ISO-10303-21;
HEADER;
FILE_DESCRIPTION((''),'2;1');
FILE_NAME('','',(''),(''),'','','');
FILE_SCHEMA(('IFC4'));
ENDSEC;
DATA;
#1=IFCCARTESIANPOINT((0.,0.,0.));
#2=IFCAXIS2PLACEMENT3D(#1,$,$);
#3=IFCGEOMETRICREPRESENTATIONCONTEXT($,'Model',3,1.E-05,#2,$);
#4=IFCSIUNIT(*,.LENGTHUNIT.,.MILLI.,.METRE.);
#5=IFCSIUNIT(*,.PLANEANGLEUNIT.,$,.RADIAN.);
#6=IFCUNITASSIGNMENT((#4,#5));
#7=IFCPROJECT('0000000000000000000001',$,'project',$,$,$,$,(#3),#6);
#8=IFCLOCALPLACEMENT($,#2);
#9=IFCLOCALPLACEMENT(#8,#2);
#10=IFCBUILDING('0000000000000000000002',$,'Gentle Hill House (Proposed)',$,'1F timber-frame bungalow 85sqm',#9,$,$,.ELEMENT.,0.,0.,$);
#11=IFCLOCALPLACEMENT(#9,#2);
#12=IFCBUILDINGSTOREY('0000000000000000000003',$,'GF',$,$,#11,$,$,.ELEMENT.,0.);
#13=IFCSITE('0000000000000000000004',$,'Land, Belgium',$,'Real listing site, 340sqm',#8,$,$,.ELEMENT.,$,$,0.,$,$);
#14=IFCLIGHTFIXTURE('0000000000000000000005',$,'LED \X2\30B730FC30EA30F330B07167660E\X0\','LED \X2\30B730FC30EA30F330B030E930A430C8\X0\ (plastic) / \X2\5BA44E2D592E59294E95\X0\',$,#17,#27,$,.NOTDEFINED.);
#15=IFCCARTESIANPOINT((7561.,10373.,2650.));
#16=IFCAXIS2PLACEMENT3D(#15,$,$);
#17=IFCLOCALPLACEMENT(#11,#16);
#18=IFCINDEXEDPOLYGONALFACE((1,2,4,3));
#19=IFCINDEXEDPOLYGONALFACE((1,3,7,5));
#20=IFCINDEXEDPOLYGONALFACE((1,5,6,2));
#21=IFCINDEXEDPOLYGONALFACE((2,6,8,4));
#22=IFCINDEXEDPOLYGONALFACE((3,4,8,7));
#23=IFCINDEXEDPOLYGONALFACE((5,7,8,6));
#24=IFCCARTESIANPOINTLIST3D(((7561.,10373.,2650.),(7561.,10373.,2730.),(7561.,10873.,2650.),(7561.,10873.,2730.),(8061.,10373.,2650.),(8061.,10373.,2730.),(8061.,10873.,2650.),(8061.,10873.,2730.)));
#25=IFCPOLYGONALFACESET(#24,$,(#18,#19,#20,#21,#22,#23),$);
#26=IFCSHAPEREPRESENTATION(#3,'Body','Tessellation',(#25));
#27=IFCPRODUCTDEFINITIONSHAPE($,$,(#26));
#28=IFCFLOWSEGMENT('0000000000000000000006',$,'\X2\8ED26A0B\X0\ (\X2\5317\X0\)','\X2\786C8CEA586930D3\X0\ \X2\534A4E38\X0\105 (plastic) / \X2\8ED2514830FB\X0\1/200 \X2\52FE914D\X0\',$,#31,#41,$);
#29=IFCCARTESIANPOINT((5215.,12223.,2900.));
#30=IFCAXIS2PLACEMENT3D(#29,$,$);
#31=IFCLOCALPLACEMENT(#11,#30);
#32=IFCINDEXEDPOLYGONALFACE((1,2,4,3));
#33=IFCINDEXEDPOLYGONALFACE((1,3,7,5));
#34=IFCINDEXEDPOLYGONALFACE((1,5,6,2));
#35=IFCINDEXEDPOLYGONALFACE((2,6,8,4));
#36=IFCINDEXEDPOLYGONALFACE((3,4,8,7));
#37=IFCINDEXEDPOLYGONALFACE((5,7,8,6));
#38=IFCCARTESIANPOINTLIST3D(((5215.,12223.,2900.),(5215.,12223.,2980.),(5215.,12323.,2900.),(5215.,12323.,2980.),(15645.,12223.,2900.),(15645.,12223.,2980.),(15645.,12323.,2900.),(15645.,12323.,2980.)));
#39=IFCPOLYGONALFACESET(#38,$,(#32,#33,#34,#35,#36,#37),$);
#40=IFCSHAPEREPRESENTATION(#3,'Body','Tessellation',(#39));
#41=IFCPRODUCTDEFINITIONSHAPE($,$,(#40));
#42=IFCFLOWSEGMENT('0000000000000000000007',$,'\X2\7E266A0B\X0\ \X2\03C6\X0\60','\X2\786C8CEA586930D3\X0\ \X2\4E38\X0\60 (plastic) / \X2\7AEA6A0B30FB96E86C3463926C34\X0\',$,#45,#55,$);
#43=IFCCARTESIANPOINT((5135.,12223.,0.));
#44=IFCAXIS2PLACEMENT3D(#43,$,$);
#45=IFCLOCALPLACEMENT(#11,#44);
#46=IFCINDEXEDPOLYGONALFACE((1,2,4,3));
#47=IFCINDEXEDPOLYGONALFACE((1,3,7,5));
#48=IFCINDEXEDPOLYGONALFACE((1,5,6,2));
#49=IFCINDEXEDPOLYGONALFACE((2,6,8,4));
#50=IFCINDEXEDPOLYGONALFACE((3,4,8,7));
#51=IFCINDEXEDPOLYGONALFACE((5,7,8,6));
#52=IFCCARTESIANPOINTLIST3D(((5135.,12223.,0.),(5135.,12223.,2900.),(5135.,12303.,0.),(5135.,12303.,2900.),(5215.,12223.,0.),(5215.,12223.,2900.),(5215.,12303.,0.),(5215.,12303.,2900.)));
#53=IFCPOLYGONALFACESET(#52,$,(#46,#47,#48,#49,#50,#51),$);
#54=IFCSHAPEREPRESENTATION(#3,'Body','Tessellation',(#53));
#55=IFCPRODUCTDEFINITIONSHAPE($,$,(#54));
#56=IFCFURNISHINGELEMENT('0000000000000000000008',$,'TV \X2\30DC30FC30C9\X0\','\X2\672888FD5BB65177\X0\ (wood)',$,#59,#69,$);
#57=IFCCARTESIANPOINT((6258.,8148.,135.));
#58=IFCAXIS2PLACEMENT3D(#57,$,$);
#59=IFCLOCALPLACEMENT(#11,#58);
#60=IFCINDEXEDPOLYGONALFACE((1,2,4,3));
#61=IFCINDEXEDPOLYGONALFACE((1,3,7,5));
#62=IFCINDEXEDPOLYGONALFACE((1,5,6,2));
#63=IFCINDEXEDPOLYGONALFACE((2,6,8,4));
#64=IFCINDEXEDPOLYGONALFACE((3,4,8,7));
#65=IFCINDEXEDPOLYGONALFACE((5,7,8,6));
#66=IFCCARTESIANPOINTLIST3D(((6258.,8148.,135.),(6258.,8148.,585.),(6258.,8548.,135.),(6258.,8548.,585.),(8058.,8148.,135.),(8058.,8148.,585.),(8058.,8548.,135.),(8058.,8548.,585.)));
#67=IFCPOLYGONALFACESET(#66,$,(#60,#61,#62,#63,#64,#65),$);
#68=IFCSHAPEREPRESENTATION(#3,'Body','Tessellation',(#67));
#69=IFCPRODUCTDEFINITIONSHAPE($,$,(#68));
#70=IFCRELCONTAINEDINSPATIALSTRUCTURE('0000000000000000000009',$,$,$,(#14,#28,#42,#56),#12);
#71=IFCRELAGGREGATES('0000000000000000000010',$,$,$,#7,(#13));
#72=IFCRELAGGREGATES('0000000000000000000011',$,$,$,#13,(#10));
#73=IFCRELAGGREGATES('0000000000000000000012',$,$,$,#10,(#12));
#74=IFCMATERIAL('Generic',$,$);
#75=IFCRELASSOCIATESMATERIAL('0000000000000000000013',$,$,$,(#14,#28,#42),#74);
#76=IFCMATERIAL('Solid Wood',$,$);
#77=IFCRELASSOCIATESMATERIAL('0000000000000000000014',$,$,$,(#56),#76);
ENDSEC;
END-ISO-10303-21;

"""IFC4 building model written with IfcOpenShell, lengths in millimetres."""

from ifc_helpers import new_model, si_unit, frame, frame_2d, origin, place, context, project, spatial, rectangle, extrude, material, element, save


model = new_model("IFC4")

# Units and contexts
model_context = context("Model", 3, precision=1e-05, world=origin())
ifc_project = project(units=[si_unit("LENGTHUNIT", "METRE", prefix="MILLI"), si_unit("PLANEANGLEUNIT", "RADIAN")], contexts=[model_context])

# Site, building, storey
site_placement = place(None, origin())
site = spatial("IfcSite", under=ifc_project, at=site_placement, Name="Land, Belgium", ObjectType="Real listing site, 340sqm", CompositionType="ELEMENT", RefElevation=0.0)
building_placement = place(site_placement, origin())
building = spatial("IfcBuilding", under=site, at=building_placement, Name="Gentle Hill House (Proposed)", ObjectType="1F timber-frame bungalow 85sqm", CompositionType="ELEMENT", ElevationOfRefHeight=0.0, ElevationOfTerrain=0.0)
storey_placement = place(building_placement, origin())
storey = spatial("IfcBuildingStorey", under=building, at=storey_placement, Name="GF", CompositionType="ELEMENT", Elevation=0.0)

# Shared definitions
ifc_material_1 = material(Name="Solid Wood")

# Shared definitions
ifc_material_2 = material(Name="Generic")

# Light fixture
light_fixture_placement = place(storey_placement, frame((7561.0, 10373.0, 2650.0)))
element("IfcLightFixture", 1, at=light_fixture_placement, inside=storey, material=ifc_material_2, Name="LED シーリング照明", Description="LED シーリングライト (plastic) / 室中央天井", PredefinedType="NOTDEFINED", context=model_context, shape_type="SweptSolid", body=[
    extrude(rectangle(XDim=500.0, YDim=500.0, at=frame_2d((250.0, 250.0))), frame((7561.0, 10373.0, 2650.0)), (0.0, 0.0, 1.0), 80.0),
])

# Flow segments
flow_segment_1_placement = place(storey_placement, frame((5215.0, 12223.0, 2900.0)))
element("IfcFlowSegment", 2, at=flow_segment_1_placement, inside=storey, material=ifc_material_2, Name="軒樋 (北)", Description="硬質塩ビ 半丸105 (plastic) / 軒先・1/200 勾配", context=model_context, shape_type="SweptSolid", body=[
    extrude(rectangle(XDim=10430.0, YDim=100.0, at=frame_2d((5215.0, 50.0))), frame((5215.0, 12223.0, 2900.0)), (0.0, 0.0, 1.0), 80.0),
])
flow_segment_2_placement = place(storey_placement, frame((5135.0, 12223.0, 0.0)))
element("IfcFlowSegment", 3, at=flow_segment_2_placement, inside=storey, material=ifc_material_2, Name="縦樋 φ60", Description="硬質塩ビ 丸60 (plastic) / 竪樋・雨水排水", context=model_context, shape_type="SweptSolid", body=[
    extrude(rectangle(XDim=80.0, YDim=80.0, at=frame_2d((40.0, 40.0))), frame((5135.0, 12223.0, 0.0)), (0.0, 0.0, 1.0), 2900.0),
])

# Furnishing element
furnishing_placement = place(storey_placement, frame((6258.0, 8148.0, 135.0)))
element("IfcFurnishingElement", 4, at=furnishing_placement, inside=storey, material=ifc_material_1, Name="TV ボード", Description="木製家具 (wood)", context=model_context, shape_type="SweptSolid", body=[
    extrude(rectangle(XDim=1800.0, YDim=400.0, at=frame_2d((900.0, 200.0))), frame((6258.0, 8148.0, 135.0)), (0.0, 0.0, 1.0), 450.0),
])

save(model, "model.ifc")
